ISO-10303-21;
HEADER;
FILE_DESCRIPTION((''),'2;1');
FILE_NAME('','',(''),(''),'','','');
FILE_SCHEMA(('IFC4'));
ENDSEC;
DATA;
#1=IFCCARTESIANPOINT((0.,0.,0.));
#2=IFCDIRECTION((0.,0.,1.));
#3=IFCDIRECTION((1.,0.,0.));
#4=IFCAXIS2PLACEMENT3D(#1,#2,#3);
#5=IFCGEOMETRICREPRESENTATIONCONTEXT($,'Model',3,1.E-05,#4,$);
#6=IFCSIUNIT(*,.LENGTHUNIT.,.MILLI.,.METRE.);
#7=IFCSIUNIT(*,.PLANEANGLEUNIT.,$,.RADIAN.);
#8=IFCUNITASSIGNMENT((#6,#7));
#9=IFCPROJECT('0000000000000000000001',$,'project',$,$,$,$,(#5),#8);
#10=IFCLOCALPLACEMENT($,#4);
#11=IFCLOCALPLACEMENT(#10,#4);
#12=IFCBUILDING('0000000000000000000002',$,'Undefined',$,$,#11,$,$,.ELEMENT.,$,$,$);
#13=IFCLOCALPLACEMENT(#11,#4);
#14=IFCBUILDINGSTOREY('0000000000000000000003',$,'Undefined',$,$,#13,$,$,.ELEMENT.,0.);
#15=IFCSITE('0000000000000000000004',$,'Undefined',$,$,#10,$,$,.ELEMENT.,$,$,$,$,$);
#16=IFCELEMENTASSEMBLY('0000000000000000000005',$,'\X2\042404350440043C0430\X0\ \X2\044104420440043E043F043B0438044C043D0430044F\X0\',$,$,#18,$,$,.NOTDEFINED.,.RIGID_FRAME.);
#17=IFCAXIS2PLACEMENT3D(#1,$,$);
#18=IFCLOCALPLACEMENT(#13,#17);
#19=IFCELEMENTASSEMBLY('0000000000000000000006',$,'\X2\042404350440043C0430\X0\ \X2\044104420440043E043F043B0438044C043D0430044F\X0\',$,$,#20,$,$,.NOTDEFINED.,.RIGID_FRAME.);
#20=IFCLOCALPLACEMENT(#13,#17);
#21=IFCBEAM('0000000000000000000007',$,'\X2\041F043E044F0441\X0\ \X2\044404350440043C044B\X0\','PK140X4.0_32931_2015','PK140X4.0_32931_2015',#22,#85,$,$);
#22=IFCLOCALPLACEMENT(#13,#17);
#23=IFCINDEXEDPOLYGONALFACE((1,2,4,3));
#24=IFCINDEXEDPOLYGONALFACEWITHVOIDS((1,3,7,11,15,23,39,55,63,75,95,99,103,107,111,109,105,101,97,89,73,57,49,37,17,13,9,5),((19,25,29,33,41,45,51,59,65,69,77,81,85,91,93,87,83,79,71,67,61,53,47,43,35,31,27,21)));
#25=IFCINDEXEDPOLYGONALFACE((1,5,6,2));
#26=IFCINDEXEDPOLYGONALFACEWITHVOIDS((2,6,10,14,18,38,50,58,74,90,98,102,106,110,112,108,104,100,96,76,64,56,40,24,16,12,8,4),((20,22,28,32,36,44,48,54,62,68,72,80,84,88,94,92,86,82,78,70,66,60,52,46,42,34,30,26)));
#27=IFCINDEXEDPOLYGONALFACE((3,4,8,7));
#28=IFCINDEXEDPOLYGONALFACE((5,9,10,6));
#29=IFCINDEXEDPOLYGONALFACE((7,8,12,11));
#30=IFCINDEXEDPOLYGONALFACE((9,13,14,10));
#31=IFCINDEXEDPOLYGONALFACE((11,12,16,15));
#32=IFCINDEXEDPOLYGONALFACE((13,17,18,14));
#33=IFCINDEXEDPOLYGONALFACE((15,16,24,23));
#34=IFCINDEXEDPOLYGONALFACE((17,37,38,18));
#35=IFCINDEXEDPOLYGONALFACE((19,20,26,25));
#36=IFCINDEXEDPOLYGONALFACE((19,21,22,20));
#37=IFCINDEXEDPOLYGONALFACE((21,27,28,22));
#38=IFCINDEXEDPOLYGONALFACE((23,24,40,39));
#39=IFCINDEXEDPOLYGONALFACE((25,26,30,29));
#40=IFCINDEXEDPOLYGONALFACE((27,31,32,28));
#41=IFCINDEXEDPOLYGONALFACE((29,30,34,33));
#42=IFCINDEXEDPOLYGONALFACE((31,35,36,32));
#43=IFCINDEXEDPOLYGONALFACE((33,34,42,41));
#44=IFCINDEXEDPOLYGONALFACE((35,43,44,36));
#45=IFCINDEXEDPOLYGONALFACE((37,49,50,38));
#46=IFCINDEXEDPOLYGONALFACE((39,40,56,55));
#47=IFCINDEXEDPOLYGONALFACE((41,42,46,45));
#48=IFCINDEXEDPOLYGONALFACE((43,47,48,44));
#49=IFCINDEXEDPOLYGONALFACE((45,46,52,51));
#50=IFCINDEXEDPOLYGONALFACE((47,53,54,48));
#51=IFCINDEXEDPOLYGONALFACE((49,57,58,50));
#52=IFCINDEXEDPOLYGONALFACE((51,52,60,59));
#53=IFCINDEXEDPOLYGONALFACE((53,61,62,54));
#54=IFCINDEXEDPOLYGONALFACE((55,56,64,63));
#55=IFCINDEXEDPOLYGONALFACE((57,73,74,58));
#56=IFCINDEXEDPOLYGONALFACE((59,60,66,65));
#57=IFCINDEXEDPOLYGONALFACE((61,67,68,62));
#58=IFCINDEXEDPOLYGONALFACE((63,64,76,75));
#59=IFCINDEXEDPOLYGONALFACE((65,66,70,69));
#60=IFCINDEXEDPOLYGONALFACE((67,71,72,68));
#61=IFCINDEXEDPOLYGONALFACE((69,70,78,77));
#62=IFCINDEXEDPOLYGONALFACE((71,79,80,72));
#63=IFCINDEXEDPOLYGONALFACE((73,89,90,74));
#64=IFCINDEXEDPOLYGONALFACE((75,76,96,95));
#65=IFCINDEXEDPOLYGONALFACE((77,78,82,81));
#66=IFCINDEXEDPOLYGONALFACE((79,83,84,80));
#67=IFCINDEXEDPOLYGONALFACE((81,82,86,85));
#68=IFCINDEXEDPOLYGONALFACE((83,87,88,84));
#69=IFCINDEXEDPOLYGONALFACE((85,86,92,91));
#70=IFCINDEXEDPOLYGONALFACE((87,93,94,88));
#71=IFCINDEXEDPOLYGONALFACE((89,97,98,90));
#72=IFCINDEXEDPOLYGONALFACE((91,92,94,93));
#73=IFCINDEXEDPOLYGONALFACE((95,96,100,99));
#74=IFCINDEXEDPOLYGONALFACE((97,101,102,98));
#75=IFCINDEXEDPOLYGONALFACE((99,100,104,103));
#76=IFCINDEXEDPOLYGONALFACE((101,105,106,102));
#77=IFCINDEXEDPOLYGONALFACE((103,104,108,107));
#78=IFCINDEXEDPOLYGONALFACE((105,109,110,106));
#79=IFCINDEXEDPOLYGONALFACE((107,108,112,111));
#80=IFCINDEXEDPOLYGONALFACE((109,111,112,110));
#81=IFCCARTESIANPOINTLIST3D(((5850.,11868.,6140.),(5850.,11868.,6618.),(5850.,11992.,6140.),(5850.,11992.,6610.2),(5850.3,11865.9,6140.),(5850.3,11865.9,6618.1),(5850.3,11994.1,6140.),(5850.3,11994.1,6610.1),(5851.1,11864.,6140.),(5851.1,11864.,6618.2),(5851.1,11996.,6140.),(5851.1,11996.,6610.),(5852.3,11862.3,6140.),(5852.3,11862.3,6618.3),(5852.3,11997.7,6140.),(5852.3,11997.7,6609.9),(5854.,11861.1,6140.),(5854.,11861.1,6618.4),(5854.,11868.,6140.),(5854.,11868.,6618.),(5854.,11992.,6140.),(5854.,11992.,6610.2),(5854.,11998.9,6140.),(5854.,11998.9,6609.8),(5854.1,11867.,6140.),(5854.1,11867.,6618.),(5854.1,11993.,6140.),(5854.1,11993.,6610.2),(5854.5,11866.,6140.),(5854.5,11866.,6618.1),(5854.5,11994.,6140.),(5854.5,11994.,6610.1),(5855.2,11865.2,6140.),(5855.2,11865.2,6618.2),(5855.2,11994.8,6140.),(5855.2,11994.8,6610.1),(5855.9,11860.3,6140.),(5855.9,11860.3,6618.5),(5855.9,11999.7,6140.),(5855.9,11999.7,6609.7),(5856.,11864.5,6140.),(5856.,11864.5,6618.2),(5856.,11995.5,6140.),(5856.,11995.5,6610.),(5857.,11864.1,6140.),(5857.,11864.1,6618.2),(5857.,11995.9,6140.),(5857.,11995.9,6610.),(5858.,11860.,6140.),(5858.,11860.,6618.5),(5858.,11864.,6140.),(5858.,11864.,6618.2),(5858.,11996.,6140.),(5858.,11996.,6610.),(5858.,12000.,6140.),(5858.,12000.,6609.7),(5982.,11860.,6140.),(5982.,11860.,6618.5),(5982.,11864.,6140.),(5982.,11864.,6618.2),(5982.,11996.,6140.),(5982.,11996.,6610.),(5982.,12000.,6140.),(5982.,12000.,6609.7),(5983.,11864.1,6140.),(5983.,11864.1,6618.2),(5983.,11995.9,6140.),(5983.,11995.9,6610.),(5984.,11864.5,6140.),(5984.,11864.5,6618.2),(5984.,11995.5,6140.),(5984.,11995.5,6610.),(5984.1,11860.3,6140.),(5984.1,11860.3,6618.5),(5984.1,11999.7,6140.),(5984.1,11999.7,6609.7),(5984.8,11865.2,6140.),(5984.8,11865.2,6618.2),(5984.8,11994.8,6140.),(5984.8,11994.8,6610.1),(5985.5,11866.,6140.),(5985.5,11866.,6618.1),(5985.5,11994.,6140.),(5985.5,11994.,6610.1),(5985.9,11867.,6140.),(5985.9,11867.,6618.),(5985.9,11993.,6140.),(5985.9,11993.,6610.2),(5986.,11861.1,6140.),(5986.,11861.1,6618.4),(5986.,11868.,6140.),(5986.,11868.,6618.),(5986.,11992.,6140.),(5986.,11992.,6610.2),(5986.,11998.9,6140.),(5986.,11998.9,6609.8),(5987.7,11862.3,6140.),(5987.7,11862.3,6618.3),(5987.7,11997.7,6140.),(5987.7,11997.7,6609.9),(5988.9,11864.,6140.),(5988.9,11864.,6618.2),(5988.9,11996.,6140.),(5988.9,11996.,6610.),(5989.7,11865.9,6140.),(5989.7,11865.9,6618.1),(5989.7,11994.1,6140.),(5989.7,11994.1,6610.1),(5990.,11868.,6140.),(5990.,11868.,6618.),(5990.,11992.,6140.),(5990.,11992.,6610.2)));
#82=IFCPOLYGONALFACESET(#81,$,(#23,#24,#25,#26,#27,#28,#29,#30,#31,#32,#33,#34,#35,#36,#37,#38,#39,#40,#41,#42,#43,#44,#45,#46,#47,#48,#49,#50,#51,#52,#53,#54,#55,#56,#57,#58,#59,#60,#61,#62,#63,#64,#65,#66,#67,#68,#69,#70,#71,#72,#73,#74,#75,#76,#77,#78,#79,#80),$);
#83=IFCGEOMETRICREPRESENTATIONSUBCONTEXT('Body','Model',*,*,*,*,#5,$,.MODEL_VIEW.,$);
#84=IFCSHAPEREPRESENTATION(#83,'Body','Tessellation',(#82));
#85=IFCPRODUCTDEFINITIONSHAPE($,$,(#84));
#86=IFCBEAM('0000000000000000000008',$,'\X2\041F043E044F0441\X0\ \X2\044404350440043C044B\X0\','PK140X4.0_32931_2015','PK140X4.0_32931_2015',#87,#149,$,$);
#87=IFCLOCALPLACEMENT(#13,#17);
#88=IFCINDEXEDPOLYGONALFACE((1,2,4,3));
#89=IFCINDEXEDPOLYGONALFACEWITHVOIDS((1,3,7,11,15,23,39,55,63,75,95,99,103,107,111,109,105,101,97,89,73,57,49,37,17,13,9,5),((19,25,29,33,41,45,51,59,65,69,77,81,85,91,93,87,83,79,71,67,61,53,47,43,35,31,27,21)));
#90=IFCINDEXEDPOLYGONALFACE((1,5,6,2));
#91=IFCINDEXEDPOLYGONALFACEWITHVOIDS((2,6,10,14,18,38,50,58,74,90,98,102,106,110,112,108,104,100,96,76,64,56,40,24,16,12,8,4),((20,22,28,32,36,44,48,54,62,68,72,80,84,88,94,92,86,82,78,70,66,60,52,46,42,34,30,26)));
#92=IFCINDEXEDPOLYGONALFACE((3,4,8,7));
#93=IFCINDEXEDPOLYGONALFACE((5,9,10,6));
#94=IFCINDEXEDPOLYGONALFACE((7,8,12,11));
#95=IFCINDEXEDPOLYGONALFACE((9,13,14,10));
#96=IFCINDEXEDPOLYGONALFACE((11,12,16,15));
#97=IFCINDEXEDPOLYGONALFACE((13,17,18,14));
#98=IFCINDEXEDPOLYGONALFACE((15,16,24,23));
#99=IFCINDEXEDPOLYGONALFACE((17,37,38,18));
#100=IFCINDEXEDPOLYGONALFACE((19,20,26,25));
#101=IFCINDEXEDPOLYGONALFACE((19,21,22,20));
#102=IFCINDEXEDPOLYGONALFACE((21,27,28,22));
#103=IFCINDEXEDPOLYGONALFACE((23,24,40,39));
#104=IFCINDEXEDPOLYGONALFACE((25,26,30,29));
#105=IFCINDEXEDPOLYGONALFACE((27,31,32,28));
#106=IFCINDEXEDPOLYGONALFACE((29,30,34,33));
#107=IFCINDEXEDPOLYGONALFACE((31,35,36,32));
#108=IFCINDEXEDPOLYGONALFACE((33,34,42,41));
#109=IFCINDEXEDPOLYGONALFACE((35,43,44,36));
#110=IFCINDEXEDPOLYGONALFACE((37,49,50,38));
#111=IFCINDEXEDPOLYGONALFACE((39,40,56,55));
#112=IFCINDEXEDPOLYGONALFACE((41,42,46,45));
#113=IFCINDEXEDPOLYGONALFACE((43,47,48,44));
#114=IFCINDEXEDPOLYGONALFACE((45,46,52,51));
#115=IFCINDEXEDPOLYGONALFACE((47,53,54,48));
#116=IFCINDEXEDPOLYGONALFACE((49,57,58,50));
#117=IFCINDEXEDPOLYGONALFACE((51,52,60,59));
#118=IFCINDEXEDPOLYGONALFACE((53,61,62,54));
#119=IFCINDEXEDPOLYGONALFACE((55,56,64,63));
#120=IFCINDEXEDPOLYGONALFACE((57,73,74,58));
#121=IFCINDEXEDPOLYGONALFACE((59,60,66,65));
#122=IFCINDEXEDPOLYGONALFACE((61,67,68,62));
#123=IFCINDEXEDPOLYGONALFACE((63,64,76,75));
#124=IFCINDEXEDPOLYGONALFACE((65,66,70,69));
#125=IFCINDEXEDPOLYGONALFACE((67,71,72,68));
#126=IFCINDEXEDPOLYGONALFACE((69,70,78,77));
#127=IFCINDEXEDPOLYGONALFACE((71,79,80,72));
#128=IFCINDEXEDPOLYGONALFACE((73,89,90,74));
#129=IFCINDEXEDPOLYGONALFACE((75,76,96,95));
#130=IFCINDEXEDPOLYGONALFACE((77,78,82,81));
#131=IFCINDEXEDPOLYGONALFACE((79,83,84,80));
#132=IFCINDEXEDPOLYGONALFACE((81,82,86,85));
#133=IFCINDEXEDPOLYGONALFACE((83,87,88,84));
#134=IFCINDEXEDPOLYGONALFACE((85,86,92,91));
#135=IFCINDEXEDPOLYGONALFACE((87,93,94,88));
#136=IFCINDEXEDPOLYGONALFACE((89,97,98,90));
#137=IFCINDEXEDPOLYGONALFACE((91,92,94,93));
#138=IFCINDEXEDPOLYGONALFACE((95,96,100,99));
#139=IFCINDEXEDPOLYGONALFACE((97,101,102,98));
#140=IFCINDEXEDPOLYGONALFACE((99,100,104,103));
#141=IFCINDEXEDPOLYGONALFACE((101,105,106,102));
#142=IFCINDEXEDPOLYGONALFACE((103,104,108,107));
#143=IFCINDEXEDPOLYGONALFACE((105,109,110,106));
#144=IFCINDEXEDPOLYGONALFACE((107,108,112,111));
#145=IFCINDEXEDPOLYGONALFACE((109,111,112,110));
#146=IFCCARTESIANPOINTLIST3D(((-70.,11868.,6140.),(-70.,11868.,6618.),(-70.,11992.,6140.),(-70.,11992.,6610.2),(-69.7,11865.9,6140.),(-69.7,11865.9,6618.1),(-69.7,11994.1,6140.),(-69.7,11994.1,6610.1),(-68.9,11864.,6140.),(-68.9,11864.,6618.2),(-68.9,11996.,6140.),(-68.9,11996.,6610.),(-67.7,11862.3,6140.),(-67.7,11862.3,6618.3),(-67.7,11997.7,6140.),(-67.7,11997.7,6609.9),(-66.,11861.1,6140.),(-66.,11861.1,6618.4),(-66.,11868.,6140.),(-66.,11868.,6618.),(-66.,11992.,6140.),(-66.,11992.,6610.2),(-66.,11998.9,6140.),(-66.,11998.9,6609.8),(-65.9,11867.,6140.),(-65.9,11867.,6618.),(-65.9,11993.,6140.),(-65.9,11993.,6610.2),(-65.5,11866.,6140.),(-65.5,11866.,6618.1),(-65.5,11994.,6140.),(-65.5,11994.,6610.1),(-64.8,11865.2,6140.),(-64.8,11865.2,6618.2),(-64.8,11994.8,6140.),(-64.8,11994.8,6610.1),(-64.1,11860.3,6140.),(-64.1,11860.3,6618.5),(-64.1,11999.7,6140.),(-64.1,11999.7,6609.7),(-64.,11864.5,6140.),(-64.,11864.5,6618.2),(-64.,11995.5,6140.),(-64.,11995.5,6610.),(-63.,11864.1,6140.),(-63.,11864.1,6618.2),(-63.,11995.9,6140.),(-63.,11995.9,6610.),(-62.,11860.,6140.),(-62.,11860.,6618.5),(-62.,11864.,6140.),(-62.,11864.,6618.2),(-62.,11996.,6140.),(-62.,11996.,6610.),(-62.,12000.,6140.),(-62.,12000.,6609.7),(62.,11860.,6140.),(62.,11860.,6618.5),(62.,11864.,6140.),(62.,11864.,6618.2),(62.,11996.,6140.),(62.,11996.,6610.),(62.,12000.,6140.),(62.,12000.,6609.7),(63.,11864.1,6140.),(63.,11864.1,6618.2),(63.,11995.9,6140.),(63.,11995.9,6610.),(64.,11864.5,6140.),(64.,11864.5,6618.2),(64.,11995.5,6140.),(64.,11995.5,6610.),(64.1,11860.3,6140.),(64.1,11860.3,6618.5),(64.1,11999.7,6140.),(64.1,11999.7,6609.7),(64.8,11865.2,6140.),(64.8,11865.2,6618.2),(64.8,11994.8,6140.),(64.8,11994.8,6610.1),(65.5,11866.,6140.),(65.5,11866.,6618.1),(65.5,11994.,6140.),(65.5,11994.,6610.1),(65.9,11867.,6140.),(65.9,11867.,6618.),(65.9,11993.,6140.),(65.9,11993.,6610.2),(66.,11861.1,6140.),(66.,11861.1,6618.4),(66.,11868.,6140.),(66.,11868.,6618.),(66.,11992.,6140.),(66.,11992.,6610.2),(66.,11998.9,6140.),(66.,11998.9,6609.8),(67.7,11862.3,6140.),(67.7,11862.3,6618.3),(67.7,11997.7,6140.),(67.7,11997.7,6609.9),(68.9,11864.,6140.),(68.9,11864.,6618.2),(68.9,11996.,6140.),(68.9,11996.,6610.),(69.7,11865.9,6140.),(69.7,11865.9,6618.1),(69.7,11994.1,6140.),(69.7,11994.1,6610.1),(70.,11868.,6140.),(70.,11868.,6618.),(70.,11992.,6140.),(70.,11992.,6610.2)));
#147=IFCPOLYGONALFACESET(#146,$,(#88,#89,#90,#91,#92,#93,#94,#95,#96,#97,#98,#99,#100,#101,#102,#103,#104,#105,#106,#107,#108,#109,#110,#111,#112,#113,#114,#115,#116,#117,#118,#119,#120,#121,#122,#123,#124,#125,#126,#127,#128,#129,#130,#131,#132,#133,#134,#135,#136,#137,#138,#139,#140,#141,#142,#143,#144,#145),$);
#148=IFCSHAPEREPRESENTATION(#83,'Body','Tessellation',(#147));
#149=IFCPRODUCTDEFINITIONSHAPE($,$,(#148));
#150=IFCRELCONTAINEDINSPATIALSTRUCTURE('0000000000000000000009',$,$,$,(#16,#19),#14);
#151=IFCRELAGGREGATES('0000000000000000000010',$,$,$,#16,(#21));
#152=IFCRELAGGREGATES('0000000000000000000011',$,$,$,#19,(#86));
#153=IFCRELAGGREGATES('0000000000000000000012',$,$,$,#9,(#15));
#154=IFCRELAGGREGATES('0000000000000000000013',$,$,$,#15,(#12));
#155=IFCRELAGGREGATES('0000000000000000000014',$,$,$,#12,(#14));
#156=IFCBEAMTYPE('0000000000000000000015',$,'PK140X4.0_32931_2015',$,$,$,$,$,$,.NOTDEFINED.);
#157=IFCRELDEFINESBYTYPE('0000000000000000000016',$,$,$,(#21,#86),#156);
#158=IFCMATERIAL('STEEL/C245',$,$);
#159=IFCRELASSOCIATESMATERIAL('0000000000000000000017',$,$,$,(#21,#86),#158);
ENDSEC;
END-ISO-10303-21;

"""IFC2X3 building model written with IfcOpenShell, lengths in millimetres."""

from ifc_helpers import new_model, si_unit, frame, origin_with_axes, origin_2d_with_axis, place, context, subcontext, project, spatial, hollow_rectangle, extrude, clip, halfspace, material, type_object, element, aggregate, save


model = new_model("IFC2X3")

# Units and contexts
model_context = context("Model", 3, precision=1e-05, world=origin_with_axes())
body_context = subcontext(model_context, "Body", "Model", "MODEL_VIEW")
ifc_project = project(units=[si_unit("LENGTHUNIT", "METRE", prefix="MILLI"), si_unit("PLANEANGLEUNIT", "RADIAN")], contexts=[model_context])

# Site, building, storey
site_placement = place(None, origin_with_axes())
site = spatial("IfcSite", under=ifc_project, at=site_placement, Name="Undefined", CompositionType="ELEMENT")
building_placement = place(site_placement, origin_with_axes())
building = spatial("IfcBuilding", under=site, at=building_placement, Name="Undefined", CompositionType="ELEMENT")
storey_placement = place(building_placement, origin_with_axes())
storey = spatial("IfcBuildingStorey", under=building, at=storey_placement, Name="Undefined", CompositionType="ELEMENT", Elevation=0.0)

# Shared definitions
ifc_material = material(Name="STEEL/C245")

# Element assemblies
assembly_1_placement = place(storey_placement, origin_with_axes())
assembly_1 = element("IfcElementAssembly", 1, at=assembly_1_placement, inside=storey, Name="Ферма строплиьная", AssemblyPlace="NOTDEFINED", PredefinedType="RIGID_FRAME")
assembly_2_placement = place(storey_placement, origin_with_axes())
assembly_2 = element("IfcElementAssembly", 2, at=assembly_2_placement, inside=storey, Name="Ферма строплиьная", AssemblyPlace="NOTDEFINED", PredefinedType="RIGID_FRAME")

# Beams
beam_type_1 = type_object("IfcBeamType", Name="PK140X4.0_32931_2015", PredefinedType="NOTDEFINED")
beam_1_placement = place(assembly_1_placement, frame((5920.0, 11930.0, 6609.7), z_axis=(1.0, 0.0, 0.0), x_axis=(0.0, 0.0, -1.0)))
beam_1 = element("IfcBeam", 3, at=beam_1_placement, type_object=beam_type_1, material=ifc_material, Name="Пояс фермы", Description="PK140X4.0_32931_2015", ObjectType="PK140X4.0_32931_2015", context=body_context, shape_type="Clipping", body=[
    clip(extrude(hollow_rectangle(XDim=140.0, YDim=140.0, WallThickness=4.0, InnerFilletRadius=4.0, OuterFilletRadius=8.0, at=origin_2d_with_axis()), frame((469.7, 0.0, 0.0), z_axis=(-1.0, 0.0, 0.0), x_axis=(0.0, -1.0, 0.0)), (0.0, 0.0, 1.0), 478.5), halfspace(frame((-14.9, -167.6, 0.0), z_axis=(-0.998053, 0.062378, 0.0), x_axis=(0.0, 0.0, 1.0)), False)),
])
aggregate(assembly_1, [beam_1])
beam_2_placement = place(assembly_2_placement, frame((0.0, 11930.0, 6609.7), z_axis=(1.0, 0.0, 0.0), x_axis=(0.0, 0.0, -1.0)))
beam_2 = element("IfcBeam", 4, at=beam_2_placement, type_object=beam_type_1, material=ifc_material, Name="Пояс фермы", Description="PK140X4.0_32931_2015", ObjectType="PK140X4.0_32931_2015", context=body_context, shape_type="Clipping", body=[
    clip(extrude(hollow_rectangle(XDim=140.0, YDim=140.0, WallThickness=4.0, InnerFilletRadius=4.0, OuterFilletRadius=8.0, at=origin_2d_with_axis()), frame((469.7, 0.0, 0.0), z_axis=(-1.0, 0.0, 0.0), x_axis=(0.0, -1.0, 0.0)), (0.0, 0.0, 1.0), 478.5), halfspace(frame((-14.9, -167.6, 0.0), z_axis=(-0.998053, 0.062378, 0.0), x_axis=(0.0, 0.0, 1.0)), False)),
])
aggregate(assembly_2, [beam_2])

save(model, "model.ifc")
